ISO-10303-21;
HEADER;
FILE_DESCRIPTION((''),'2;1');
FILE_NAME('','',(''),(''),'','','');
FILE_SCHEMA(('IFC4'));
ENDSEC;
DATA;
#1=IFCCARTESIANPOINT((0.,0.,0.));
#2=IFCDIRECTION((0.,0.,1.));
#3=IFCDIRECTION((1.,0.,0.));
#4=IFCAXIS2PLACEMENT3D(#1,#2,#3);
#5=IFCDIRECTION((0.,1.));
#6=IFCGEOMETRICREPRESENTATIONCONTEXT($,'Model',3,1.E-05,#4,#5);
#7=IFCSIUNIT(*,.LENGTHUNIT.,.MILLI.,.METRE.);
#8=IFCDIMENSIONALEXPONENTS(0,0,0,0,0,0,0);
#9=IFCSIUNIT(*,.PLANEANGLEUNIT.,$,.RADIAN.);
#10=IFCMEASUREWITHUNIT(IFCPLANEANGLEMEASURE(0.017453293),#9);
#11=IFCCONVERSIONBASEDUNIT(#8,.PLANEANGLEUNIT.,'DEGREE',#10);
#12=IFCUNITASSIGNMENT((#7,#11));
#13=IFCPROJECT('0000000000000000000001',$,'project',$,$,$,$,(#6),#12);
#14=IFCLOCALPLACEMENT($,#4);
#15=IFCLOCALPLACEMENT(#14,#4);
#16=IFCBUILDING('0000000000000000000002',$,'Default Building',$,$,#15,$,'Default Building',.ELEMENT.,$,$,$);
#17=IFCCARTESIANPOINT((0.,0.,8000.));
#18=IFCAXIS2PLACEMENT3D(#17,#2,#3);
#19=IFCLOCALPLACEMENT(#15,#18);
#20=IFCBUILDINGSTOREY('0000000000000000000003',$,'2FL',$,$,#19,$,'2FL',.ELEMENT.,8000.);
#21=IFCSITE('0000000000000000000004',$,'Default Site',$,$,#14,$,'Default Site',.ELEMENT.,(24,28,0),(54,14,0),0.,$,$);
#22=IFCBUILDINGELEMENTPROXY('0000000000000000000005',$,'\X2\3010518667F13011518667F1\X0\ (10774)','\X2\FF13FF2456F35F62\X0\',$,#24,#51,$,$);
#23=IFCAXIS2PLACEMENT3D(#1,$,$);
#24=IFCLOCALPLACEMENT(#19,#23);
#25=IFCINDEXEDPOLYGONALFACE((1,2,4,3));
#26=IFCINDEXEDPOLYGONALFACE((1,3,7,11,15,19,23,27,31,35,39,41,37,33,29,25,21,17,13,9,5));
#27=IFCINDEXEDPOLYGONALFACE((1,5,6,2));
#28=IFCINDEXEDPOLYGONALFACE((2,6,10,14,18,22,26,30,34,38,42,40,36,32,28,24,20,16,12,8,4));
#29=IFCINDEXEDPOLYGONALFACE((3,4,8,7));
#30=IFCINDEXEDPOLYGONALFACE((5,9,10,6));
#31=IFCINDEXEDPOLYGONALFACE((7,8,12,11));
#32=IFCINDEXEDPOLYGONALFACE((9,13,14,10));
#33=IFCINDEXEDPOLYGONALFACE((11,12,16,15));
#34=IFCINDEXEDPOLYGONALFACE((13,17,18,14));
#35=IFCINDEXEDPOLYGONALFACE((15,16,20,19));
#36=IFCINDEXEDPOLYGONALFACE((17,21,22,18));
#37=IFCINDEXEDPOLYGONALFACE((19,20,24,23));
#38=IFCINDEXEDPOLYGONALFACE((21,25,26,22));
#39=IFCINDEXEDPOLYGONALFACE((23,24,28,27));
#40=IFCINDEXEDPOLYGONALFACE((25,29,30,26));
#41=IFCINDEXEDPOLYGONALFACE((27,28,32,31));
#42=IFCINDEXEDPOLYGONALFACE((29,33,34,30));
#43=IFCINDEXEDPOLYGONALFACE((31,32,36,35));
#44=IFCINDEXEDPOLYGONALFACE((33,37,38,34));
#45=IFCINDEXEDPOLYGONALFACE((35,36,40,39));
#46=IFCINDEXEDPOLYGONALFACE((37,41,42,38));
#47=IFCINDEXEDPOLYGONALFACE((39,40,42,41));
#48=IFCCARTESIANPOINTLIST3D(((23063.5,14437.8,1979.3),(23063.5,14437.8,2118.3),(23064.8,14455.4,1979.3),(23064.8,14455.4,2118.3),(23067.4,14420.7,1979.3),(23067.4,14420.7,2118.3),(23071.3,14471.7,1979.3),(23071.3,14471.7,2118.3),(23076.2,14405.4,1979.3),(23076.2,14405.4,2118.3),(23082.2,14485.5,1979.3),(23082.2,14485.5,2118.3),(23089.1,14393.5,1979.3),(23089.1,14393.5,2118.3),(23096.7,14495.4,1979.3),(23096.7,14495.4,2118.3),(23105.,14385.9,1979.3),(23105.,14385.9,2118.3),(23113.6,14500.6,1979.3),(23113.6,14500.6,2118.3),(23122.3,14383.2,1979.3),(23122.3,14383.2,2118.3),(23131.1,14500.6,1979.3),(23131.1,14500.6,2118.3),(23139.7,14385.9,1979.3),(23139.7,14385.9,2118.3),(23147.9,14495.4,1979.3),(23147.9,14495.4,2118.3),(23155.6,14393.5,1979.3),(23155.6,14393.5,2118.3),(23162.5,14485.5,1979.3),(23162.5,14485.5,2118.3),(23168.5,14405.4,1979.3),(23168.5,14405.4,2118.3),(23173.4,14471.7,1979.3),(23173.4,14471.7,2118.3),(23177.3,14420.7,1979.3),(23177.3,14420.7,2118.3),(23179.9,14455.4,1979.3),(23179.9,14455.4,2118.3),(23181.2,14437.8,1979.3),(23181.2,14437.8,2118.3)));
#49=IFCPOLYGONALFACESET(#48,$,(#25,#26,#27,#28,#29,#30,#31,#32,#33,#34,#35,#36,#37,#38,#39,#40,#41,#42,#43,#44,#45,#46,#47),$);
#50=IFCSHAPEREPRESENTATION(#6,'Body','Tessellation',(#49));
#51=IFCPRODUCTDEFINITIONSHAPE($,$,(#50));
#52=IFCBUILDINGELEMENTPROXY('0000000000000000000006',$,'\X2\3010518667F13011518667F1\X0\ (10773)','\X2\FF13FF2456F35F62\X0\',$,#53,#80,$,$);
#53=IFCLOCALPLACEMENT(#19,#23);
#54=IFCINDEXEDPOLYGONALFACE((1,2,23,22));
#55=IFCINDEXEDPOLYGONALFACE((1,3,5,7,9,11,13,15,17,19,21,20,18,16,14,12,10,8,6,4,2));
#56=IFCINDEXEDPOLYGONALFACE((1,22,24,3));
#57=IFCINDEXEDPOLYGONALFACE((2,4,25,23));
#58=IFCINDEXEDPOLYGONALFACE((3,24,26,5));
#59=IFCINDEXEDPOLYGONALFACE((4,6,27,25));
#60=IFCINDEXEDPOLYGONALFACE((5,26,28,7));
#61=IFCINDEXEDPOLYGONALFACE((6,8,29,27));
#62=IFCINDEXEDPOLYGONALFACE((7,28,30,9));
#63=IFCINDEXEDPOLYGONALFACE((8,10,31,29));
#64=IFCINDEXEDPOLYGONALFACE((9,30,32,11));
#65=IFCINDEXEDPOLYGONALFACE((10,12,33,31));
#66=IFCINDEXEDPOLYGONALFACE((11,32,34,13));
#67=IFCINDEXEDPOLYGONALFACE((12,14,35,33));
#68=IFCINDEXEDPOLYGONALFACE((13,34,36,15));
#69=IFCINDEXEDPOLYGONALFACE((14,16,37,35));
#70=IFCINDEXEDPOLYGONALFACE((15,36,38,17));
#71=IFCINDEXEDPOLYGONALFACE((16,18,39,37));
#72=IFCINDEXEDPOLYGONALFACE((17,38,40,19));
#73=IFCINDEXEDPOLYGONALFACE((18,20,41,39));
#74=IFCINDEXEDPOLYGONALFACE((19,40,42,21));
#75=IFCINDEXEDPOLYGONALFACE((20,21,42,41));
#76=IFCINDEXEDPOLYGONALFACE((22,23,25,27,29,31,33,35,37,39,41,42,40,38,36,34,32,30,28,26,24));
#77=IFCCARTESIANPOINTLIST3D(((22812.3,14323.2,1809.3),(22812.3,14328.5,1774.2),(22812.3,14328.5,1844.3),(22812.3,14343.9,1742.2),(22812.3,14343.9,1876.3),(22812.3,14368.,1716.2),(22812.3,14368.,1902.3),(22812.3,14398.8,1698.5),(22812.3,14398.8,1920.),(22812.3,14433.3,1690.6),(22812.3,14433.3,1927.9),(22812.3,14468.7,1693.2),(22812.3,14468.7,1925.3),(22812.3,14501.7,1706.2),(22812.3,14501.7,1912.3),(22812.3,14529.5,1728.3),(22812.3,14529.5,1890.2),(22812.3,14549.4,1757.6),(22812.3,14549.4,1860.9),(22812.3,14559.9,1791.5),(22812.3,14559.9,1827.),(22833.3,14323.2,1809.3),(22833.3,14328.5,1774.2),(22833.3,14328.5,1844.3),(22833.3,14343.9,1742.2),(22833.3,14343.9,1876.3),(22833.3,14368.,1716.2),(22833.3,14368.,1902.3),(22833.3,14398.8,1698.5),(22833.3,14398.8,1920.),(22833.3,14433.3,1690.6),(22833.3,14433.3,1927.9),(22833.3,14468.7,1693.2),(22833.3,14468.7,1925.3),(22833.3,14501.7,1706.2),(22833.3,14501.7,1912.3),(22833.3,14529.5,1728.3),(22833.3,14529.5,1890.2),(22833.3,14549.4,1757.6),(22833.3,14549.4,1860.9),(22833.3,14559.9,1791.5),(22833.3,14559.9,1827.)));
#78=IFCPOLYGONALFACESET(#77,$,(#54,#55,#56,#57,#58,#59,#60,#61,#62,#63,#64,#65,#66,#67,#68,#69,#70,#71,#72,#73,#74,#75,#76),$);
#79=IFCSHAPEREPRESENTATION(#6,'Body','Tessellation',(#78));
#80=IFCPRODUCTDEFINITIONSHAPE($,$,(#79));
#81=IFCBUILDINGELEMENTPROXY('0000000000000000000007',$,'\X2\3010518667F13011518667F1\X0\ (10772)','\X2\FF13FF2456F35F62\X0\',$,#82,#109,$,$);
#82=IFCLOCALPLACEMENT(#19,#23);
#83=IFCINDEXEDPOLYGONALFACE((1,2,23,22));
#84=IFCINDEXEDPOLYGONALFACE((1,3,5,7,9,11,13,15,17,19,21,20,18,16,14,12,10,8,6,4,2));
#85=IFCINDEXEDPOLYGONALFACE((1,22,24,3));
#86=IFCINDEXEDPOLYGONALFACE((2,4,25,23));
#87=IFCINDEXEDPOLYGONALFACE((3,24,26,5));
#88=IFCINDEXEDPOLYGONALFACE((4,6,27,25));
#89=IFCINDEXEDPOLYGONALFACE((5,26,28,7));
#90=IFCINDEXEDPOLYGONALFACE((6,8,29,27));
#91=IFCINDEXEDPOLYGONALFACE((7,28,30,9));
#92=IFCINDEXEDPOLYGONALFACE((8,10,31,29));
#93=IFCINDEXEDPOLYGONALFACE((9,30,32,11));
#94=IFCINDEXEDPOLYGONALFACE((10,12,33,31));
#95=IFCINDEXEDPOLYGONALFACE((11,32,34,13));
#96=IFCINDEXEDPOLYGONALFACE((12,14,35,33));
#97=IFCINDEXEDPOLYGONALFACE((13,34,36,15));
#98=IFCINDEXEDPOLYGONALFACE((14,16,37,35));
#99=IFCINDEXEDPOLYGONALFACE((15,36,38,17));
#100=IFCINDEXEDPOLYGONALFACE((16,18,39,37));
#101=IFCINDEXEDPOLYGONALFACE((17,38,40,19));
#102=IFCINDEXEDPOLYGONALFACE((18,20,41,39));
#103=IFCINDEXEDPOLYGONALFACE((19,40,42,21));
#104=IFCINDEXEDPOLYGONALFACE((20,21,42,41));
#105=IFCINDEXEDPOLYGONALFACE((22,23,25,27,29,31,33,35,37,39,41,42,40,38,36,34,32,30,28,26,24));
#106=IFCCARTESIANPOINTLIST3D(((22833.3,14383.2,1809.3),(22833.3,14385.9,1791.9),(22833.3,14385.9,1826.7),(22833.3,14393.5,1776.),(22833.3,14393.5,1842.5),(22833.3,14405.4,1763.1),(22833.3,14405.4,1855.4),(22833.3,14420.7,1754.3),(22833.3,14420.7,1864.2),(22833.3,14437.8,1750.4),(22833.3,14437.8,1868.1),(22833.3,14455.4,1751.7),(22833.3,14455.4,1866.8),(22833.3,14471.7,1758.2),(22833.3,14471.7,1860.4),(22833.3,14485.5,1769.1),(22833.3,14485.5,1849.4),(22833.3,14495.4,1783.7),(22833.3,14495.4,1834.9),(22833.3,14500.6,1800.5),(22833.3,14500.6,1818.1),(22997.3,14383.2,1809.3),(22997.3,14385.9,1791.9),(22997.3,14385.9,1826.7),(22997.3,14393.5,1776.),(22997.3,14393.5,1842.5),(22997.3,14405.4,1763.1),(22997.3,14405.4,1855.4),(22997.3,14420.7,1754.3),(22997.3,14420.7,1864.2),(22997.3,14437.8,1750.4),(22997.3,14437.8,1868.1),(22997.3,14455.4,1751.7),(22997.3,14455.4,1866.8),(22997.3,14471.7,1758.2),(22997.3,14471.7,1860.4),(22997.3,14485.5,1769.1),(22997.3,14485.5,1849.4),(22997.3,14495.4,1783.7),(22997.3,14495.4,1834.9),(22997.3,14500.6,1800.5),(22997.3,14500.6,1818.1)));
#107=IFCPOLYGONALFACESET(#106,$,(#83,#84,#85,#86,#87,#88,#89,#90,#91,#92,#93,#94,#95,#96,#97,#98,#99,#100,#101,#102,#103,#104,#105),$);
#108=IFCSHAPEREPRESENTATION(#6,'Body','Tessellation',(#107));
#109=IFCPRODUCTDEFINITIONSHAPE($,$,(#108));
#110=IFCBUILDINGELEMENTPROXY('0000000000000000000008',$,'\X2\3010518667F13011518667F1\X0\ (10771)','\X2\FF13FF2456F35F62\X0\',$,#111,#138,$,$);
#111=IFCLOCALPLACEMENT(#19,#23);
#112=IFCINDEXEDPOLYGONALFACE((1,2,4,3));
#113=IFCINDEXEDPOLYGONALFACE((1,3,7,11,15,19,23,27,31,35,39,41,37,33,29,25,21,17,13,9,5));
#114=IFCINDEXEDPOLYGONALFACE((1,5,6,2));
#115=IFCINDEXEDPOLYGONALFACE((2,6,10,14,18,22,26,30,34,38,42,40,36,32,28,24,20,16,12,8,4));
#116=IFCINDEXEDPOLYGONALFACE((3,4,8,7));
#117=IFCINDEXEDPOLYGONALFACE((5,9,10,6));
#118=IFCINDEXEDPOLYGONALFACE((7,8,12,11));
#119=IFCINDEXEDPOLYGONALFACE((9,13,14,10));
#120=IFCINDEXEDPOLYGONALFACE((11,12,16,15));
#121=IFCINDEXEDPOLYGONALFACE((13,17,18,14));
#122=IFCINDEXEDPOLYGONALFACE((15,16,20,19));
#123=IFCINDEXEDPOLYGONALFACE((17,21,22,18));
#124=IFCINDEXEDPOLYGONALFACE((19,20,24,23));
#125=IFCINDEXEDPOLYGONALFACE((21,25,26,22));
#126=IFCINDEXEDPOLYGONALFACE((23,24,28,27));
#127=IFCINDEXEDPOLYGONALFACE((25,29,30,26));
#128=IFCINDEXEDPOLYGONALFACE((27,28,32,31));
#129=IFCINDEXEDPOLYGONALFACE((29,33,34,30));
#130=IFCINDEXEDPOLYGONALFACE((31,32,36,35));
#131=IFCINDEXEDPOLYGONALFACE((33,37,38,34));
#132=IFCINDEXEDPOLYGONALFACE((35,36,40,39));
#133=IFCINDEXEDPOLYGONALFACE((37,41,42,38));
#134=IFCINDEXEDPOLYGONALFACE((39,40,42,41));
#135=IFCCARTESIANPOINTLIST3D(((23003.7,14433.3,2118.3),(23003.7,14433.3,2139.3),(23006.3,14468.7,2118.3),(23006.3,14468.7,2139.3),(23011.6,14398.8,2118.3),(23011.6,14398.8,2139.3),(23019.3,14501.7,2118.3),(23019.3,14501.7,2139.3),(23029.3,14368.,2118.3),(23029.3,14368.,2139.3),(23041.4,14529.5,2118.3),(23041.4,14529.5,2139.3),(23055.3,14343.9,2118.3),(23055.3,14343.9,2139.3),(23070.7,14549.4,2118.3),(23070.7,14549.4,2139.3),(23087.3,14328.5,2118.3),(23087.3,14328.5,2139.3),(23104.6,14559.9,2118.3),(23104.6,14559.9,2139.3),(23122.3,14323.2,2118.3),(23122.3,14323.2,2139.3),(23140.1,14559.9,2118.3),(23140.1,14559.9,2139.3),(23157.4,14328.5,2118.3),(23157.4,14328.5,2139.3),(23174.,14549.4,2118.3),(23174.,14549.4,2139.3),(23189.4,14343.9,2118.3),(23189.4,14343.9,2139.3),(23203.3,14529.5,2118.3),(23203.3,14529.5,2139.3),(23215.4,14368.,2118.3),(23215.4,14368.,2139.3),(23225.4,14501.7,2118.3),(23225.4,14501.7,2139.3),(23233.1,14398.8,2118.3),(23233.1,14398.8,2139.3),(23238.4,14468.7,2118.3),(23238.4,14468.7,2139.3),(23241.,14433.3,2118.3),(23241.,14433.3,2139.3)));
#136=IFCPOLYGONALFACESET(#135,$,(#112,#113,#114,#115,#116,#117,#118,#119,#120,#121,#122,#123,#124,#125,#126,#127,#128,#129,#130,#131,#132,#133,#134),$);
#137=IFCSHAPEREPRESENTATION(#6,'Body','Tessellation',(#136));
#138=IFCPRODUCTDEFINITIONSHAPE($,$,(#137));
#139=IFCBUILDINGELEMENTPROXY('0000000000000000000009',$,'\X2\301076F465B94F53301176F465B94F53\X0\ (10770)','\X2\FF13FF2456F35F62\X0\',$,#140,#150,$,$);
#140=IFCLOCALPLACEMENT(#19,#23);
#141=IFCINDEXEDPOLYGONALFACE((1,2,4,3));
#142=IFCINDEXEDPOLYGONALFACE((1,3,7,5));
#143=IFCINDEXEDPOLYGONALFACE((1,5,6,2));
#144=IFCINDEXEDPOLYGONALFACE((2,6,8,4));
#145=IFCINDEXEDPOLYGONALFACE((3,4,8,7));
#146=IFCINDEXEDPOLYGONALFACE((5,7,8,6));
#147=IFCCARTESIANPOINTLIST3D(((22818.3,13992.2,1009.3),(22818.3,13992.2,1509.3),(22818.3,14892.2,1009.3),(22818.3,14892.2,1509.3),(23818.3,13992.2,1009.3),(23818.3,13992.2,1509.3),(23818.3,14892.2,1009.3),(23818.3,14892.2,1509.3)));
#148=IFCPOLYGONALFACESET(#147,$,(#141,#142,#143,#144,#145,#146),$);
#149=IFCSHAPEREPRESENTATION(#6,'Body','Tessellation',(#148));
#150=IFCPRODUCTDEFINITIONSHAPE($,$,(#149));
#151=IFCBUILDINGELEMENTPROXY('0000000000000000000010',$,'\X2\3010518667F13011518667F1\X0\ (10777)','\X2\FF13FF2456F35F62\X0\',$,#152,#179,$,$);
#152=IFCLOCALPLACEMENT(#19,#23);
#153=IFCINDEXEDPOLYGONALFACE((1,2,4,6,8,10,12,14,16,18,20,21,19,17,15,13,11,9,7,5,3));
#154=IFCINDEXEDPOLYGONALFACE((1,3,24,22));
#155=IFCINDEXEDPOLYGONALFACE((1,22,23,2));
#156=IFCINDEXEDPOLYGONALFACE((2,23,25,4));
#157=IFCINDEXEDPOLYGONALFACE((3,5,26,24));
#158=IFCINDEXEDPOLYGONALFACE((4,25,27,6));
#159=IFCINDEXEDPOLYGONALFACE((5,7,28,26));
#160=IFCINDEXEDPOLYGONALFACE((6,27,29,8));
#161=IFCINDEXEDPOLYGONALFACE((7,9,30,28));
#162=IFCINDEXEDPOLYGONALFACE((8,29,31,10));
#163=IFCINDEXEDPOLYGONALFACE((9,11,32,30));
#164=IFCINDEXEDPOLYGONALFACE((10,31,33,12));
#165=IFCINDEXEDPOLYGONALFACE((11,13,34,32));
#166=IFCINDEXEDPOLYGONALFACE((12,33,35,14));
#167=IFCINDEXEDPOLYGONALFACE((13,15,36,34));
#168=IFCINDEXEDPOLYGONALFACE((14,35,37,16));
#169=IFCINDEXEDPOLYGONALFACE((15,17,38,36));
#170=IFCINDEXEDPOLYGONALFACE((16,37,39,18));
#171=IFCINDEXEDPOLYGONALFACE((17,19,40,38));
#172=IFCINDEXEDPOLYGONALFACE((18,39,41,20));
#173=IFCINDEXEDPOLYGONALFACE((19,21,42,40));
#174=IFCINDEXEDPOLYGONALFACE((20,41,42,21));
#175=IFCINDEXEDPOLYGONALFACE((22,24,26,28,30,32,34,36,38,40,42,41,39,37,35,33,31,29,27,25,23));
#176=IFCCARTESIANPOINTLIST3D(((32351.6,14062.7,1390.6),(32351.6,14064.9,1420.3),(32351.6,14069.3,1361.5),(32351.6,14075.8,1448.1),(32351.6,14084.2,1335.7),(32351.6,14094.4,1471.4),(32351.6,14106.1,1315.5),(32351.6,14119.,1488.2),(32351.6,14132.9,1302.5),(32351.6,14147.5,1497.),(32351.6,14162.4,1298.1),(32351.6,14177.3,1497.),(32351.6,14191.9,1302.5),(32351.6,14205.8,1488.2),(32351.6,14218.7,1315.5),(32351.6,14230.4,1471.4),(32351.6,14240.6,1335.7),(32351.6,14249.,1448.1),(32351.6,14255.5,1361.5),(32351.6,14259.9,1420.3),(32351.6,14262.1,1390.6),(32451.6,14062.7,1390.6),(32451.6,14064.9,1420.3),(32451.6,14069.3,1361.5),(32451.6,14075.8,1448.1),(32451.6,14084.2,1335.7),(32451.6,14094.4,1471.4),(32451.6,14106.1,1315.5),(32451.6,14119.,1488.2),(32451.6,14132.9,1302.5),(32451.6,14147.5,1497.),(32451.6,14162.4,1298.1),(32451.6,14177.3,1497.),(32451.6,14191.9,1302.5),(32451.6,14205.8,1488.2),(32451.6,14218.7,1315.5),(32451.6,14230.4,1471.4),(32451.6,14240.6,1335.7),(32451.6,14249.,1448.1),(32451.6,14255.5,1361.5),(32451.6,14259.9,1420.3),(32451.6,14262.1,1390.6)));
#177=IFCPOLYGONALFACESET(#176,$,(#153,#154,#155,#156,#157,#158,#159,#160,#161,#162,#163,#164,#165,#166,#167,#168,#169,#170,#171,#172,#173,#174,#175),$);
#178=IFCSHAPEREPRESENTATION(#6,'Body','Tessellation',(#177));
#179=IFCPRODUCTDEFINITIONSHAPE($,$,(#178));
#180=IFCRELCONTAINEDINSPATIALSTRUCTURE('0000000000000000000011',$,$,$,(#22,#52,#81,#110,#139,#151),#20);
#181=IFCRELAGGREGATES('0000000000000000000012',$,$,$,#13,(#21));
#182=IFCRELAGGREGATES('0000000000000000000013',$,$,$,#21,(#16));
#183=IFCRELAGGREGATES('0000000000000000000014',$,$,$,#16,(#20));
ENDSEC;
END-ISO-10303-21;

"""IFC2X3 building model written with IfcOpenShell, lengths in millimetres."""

from ifc_helpers import new_model, entity, si_unit, converted_unit, direction, frame, origin_with_axes, origin_2d_with_axis, place, context, project, spatial, rectangle, circle, extrude, source, transform, mapped, element, save


model = new_model("IFC2X3")

# Units and contexts
model_context = context("Model", 3, precision=1e-05, world=origin_with_axes(), true_north=direction((0.0, 1.0)))
ifc_project = project(units=[si_unit("LENGTHUNIT", "METRE", prefix="MILLI"), converted_unit("PLANEANGLEUNIT", "DEGREE", entity("IfcPlaneAngleMeasure", 0.017453293), si_unit("PLANEANGLEUNIT", "RADIAN"), dimensions=[0, 0, 0, 0, 0, 0, 0])], contexts=[model_context])

# Site, building, storey
site_placement = place(None, origin_with_axes())
site = spatial("IfcSite", under=ifc_project, at=site_placement, Name="Default Site", LongName="Default Site", CompositionType="ELEMENT", RefLatitude=(24, 28, 0), RefLongitude=(54, 14, 0), RefElevation=0.0)
building_placement = place(site_placement, origin_with_axes())
building = spatial("IfcBuilding", under=site, at=building_placement, Name="Default Building", LongName="Default Building", CompositionType="ELEMENT")
storey_placement = place(building_placement, frame((0.0, 0.0, 8000.0), z_axis=(0.0, 0.0, 1.0), x_axis=(1.0, 0.0, 0.0)))
storey = spatial("IfcBuildingStorey", under=building, at=storey_placement, Name="2FL", LongName="2FL", CompositionType="ELEMENT", Elevation=8000.0)

# Building element proxies
shared_shape_1 = source(origin_with_axes(), model_context, "Body", "SweptSolid", [
    extrude(circle(Radius=59.0, at=origin_2d_with_axis()), frame((0.0, 0.0, 0.0), z_axis=(0.0, 0.0, 1.0), x_axis=(1.0, 0.0, 0.0)), (0.0, 0.0, 1.0), 139.0),
])
proxy_1_placement = place(storey_placement, frame((23122.3, 14442.2, 1979.3), z_axis=(0.0, 0.0, 1.0), x_axis=(0.0, -1.0, 0.0)))
element("IfcBuildingElementProxy", 1, at=proxy_1_placement, inside=storey, Name="【円柱】円柱 (10774)", Description="３Ｄ図形", context=model_context, shape_type="MappedRepresentation", body=[
    mapped(shared_shape_1, transform((0.0, 0.0, 0.0))),
])
shared_shape_2 = source(origin_with_axes(), model_context, "Body", "SweptSolid", [
    extrude(circle(Radius=119.0, at=origin_2d_with_axis()), frame((0.0, 0.0, 0.0), z_axis=(0.0, 0.0, 1.0), x_axis=(1.0, 0.0, 0.0)), (0.0, 0.0, 1.0), 21.0),
])
proxy_2_placement = place(storey_placement, frame((22812.3, 14442.2, 1809.3), z_axis=(1.0, 0.0, 0.0), x_axis=(0.0, -1.0, 0.0)))
element("IfcBuildingElementProxy", 2, at=proxy_2_placement, inside=storey, Name="【円柱】円柱 (10773)", Description="３Ｄ図形", context=model_context, shape_type="MappedRepresentation", body=[
    mapped(shared_shape_2, transform((0.0, 0.0, 0.0))),
])
shared_shape_3 = source(origin_with_axes(), model_context, "Body", "SweptSolid", [
    extrude(circle(Radius=59.0, at=origin_2d_with_axis()), frame((0.0, 0.0, 0.0), z_axis=(0.0, 0.0, 1.0), x_axis=(1.0, 0.0, 0.0)), (0.0, 0.0, 1.0), 164.0),
])
proxy_3_placement = place(storey_placement, frame((22997.3, 14442.2, 1809.3), z_axis=(-1.0, 0.0, 0.0), x_axis=(0.0, -1.0, 0.0)))
element("IfcBuildingElementProxy", 3, at=proxy_3_placement, inside=storey, Name="【円柱】円柱 (10772)", Description="３Ｄ図形", context=model_context, shape_type="MappedRepresentation", body=[
    mapped(shared_shape_3, transform((0.0, 0.0, 0.0))),
])
shared_shape_4 = source(origin_with_axes(), model_context, "Body", "SweptSolid", [
    extrude(circle(Radius=119.0, at=origin_2d_with_axis()), frame((0.0, 0.0, 0.0), z_axis=(0.0, 0.0, 1.0), x_axis=(1.0, 0.0, 0.0)), (0.0, 0.0, 1.0), 21.0),
])
proxy_4_placement = place(storey_placement, frame((23122.3, 14442.2, 2139.3), z_axis=(0.0, 0.0, -1.0), x_axis=(0.0, -1.0, 0.0)))
element("IfcBuildingElementProxy", 4, at=proxy_4_placement, inside=storey, Name="【円柱】円柱 (10771)", Description="３Ｄ図形", context=model_context, shape_type="MappedRepresentation", body=[
    mapped(shared_shape_4, transform((0.0, 0.0, 0.0))),
])
shared_shape_5 = source(origin_with_axes(), model_context, "Body", "SweptSolid", [
    extrude(rectangle(XDim=1000.0, YDim=900.0, at=origin_2d_with_axis()), origin_with_axes(), (0.0, 0.0, 1.0), 500.0),
])
proxy_5_placement = place(storey_placement, frame((23318.3, 14442.2, 1009.3), z_axis=(0.0, 0.0, 1.0), x_axis=(1.0, 0.0, 0.0)))
element("IfcBuildingElementProxy", 5, at=proxy_5_placement, inside=storey, Name="【直方体】直方体 (10770)", Description="３Ｄ図形", context=model_context, shape_type="MappedRepresentation", body=[
    mapped(shared_shape_5, transform((0.0, 0.0, 0.0))),
])
shared_shape_6 = source(origin_with_axes(), model_context, "Body", "SweptSolid", [
    extrude(circle(Radius=100.0, at=origin_2d_with_axis()), frame((0.0, 0.0, 0.0), z_axis=(0.0, 0.0, 1.0), x_axis=(1.0, 0.0, 0.0)), (0.0, 0.0, 1.0), 100.0),
])
proxy_6_placement = place(storey_placement, frame((32351.6, 14162.4, 1398.1), z_axis=(1.0, 0.0, 0.0), x_axis=(0.0, 0.0, -1.0)))
element("IfcBuildingElementProxy", 6, at=proxy_6_placement, inside=storey, Name="【円柱】円柱 (10777)", Description="３Ｄ図形", context=model_context, shape_type="MappedRepresentation", body=[
    mapped(shared_shape_6, transform((0.0, 0.0, 0.0))),
])

save(model, "model.ifc")
